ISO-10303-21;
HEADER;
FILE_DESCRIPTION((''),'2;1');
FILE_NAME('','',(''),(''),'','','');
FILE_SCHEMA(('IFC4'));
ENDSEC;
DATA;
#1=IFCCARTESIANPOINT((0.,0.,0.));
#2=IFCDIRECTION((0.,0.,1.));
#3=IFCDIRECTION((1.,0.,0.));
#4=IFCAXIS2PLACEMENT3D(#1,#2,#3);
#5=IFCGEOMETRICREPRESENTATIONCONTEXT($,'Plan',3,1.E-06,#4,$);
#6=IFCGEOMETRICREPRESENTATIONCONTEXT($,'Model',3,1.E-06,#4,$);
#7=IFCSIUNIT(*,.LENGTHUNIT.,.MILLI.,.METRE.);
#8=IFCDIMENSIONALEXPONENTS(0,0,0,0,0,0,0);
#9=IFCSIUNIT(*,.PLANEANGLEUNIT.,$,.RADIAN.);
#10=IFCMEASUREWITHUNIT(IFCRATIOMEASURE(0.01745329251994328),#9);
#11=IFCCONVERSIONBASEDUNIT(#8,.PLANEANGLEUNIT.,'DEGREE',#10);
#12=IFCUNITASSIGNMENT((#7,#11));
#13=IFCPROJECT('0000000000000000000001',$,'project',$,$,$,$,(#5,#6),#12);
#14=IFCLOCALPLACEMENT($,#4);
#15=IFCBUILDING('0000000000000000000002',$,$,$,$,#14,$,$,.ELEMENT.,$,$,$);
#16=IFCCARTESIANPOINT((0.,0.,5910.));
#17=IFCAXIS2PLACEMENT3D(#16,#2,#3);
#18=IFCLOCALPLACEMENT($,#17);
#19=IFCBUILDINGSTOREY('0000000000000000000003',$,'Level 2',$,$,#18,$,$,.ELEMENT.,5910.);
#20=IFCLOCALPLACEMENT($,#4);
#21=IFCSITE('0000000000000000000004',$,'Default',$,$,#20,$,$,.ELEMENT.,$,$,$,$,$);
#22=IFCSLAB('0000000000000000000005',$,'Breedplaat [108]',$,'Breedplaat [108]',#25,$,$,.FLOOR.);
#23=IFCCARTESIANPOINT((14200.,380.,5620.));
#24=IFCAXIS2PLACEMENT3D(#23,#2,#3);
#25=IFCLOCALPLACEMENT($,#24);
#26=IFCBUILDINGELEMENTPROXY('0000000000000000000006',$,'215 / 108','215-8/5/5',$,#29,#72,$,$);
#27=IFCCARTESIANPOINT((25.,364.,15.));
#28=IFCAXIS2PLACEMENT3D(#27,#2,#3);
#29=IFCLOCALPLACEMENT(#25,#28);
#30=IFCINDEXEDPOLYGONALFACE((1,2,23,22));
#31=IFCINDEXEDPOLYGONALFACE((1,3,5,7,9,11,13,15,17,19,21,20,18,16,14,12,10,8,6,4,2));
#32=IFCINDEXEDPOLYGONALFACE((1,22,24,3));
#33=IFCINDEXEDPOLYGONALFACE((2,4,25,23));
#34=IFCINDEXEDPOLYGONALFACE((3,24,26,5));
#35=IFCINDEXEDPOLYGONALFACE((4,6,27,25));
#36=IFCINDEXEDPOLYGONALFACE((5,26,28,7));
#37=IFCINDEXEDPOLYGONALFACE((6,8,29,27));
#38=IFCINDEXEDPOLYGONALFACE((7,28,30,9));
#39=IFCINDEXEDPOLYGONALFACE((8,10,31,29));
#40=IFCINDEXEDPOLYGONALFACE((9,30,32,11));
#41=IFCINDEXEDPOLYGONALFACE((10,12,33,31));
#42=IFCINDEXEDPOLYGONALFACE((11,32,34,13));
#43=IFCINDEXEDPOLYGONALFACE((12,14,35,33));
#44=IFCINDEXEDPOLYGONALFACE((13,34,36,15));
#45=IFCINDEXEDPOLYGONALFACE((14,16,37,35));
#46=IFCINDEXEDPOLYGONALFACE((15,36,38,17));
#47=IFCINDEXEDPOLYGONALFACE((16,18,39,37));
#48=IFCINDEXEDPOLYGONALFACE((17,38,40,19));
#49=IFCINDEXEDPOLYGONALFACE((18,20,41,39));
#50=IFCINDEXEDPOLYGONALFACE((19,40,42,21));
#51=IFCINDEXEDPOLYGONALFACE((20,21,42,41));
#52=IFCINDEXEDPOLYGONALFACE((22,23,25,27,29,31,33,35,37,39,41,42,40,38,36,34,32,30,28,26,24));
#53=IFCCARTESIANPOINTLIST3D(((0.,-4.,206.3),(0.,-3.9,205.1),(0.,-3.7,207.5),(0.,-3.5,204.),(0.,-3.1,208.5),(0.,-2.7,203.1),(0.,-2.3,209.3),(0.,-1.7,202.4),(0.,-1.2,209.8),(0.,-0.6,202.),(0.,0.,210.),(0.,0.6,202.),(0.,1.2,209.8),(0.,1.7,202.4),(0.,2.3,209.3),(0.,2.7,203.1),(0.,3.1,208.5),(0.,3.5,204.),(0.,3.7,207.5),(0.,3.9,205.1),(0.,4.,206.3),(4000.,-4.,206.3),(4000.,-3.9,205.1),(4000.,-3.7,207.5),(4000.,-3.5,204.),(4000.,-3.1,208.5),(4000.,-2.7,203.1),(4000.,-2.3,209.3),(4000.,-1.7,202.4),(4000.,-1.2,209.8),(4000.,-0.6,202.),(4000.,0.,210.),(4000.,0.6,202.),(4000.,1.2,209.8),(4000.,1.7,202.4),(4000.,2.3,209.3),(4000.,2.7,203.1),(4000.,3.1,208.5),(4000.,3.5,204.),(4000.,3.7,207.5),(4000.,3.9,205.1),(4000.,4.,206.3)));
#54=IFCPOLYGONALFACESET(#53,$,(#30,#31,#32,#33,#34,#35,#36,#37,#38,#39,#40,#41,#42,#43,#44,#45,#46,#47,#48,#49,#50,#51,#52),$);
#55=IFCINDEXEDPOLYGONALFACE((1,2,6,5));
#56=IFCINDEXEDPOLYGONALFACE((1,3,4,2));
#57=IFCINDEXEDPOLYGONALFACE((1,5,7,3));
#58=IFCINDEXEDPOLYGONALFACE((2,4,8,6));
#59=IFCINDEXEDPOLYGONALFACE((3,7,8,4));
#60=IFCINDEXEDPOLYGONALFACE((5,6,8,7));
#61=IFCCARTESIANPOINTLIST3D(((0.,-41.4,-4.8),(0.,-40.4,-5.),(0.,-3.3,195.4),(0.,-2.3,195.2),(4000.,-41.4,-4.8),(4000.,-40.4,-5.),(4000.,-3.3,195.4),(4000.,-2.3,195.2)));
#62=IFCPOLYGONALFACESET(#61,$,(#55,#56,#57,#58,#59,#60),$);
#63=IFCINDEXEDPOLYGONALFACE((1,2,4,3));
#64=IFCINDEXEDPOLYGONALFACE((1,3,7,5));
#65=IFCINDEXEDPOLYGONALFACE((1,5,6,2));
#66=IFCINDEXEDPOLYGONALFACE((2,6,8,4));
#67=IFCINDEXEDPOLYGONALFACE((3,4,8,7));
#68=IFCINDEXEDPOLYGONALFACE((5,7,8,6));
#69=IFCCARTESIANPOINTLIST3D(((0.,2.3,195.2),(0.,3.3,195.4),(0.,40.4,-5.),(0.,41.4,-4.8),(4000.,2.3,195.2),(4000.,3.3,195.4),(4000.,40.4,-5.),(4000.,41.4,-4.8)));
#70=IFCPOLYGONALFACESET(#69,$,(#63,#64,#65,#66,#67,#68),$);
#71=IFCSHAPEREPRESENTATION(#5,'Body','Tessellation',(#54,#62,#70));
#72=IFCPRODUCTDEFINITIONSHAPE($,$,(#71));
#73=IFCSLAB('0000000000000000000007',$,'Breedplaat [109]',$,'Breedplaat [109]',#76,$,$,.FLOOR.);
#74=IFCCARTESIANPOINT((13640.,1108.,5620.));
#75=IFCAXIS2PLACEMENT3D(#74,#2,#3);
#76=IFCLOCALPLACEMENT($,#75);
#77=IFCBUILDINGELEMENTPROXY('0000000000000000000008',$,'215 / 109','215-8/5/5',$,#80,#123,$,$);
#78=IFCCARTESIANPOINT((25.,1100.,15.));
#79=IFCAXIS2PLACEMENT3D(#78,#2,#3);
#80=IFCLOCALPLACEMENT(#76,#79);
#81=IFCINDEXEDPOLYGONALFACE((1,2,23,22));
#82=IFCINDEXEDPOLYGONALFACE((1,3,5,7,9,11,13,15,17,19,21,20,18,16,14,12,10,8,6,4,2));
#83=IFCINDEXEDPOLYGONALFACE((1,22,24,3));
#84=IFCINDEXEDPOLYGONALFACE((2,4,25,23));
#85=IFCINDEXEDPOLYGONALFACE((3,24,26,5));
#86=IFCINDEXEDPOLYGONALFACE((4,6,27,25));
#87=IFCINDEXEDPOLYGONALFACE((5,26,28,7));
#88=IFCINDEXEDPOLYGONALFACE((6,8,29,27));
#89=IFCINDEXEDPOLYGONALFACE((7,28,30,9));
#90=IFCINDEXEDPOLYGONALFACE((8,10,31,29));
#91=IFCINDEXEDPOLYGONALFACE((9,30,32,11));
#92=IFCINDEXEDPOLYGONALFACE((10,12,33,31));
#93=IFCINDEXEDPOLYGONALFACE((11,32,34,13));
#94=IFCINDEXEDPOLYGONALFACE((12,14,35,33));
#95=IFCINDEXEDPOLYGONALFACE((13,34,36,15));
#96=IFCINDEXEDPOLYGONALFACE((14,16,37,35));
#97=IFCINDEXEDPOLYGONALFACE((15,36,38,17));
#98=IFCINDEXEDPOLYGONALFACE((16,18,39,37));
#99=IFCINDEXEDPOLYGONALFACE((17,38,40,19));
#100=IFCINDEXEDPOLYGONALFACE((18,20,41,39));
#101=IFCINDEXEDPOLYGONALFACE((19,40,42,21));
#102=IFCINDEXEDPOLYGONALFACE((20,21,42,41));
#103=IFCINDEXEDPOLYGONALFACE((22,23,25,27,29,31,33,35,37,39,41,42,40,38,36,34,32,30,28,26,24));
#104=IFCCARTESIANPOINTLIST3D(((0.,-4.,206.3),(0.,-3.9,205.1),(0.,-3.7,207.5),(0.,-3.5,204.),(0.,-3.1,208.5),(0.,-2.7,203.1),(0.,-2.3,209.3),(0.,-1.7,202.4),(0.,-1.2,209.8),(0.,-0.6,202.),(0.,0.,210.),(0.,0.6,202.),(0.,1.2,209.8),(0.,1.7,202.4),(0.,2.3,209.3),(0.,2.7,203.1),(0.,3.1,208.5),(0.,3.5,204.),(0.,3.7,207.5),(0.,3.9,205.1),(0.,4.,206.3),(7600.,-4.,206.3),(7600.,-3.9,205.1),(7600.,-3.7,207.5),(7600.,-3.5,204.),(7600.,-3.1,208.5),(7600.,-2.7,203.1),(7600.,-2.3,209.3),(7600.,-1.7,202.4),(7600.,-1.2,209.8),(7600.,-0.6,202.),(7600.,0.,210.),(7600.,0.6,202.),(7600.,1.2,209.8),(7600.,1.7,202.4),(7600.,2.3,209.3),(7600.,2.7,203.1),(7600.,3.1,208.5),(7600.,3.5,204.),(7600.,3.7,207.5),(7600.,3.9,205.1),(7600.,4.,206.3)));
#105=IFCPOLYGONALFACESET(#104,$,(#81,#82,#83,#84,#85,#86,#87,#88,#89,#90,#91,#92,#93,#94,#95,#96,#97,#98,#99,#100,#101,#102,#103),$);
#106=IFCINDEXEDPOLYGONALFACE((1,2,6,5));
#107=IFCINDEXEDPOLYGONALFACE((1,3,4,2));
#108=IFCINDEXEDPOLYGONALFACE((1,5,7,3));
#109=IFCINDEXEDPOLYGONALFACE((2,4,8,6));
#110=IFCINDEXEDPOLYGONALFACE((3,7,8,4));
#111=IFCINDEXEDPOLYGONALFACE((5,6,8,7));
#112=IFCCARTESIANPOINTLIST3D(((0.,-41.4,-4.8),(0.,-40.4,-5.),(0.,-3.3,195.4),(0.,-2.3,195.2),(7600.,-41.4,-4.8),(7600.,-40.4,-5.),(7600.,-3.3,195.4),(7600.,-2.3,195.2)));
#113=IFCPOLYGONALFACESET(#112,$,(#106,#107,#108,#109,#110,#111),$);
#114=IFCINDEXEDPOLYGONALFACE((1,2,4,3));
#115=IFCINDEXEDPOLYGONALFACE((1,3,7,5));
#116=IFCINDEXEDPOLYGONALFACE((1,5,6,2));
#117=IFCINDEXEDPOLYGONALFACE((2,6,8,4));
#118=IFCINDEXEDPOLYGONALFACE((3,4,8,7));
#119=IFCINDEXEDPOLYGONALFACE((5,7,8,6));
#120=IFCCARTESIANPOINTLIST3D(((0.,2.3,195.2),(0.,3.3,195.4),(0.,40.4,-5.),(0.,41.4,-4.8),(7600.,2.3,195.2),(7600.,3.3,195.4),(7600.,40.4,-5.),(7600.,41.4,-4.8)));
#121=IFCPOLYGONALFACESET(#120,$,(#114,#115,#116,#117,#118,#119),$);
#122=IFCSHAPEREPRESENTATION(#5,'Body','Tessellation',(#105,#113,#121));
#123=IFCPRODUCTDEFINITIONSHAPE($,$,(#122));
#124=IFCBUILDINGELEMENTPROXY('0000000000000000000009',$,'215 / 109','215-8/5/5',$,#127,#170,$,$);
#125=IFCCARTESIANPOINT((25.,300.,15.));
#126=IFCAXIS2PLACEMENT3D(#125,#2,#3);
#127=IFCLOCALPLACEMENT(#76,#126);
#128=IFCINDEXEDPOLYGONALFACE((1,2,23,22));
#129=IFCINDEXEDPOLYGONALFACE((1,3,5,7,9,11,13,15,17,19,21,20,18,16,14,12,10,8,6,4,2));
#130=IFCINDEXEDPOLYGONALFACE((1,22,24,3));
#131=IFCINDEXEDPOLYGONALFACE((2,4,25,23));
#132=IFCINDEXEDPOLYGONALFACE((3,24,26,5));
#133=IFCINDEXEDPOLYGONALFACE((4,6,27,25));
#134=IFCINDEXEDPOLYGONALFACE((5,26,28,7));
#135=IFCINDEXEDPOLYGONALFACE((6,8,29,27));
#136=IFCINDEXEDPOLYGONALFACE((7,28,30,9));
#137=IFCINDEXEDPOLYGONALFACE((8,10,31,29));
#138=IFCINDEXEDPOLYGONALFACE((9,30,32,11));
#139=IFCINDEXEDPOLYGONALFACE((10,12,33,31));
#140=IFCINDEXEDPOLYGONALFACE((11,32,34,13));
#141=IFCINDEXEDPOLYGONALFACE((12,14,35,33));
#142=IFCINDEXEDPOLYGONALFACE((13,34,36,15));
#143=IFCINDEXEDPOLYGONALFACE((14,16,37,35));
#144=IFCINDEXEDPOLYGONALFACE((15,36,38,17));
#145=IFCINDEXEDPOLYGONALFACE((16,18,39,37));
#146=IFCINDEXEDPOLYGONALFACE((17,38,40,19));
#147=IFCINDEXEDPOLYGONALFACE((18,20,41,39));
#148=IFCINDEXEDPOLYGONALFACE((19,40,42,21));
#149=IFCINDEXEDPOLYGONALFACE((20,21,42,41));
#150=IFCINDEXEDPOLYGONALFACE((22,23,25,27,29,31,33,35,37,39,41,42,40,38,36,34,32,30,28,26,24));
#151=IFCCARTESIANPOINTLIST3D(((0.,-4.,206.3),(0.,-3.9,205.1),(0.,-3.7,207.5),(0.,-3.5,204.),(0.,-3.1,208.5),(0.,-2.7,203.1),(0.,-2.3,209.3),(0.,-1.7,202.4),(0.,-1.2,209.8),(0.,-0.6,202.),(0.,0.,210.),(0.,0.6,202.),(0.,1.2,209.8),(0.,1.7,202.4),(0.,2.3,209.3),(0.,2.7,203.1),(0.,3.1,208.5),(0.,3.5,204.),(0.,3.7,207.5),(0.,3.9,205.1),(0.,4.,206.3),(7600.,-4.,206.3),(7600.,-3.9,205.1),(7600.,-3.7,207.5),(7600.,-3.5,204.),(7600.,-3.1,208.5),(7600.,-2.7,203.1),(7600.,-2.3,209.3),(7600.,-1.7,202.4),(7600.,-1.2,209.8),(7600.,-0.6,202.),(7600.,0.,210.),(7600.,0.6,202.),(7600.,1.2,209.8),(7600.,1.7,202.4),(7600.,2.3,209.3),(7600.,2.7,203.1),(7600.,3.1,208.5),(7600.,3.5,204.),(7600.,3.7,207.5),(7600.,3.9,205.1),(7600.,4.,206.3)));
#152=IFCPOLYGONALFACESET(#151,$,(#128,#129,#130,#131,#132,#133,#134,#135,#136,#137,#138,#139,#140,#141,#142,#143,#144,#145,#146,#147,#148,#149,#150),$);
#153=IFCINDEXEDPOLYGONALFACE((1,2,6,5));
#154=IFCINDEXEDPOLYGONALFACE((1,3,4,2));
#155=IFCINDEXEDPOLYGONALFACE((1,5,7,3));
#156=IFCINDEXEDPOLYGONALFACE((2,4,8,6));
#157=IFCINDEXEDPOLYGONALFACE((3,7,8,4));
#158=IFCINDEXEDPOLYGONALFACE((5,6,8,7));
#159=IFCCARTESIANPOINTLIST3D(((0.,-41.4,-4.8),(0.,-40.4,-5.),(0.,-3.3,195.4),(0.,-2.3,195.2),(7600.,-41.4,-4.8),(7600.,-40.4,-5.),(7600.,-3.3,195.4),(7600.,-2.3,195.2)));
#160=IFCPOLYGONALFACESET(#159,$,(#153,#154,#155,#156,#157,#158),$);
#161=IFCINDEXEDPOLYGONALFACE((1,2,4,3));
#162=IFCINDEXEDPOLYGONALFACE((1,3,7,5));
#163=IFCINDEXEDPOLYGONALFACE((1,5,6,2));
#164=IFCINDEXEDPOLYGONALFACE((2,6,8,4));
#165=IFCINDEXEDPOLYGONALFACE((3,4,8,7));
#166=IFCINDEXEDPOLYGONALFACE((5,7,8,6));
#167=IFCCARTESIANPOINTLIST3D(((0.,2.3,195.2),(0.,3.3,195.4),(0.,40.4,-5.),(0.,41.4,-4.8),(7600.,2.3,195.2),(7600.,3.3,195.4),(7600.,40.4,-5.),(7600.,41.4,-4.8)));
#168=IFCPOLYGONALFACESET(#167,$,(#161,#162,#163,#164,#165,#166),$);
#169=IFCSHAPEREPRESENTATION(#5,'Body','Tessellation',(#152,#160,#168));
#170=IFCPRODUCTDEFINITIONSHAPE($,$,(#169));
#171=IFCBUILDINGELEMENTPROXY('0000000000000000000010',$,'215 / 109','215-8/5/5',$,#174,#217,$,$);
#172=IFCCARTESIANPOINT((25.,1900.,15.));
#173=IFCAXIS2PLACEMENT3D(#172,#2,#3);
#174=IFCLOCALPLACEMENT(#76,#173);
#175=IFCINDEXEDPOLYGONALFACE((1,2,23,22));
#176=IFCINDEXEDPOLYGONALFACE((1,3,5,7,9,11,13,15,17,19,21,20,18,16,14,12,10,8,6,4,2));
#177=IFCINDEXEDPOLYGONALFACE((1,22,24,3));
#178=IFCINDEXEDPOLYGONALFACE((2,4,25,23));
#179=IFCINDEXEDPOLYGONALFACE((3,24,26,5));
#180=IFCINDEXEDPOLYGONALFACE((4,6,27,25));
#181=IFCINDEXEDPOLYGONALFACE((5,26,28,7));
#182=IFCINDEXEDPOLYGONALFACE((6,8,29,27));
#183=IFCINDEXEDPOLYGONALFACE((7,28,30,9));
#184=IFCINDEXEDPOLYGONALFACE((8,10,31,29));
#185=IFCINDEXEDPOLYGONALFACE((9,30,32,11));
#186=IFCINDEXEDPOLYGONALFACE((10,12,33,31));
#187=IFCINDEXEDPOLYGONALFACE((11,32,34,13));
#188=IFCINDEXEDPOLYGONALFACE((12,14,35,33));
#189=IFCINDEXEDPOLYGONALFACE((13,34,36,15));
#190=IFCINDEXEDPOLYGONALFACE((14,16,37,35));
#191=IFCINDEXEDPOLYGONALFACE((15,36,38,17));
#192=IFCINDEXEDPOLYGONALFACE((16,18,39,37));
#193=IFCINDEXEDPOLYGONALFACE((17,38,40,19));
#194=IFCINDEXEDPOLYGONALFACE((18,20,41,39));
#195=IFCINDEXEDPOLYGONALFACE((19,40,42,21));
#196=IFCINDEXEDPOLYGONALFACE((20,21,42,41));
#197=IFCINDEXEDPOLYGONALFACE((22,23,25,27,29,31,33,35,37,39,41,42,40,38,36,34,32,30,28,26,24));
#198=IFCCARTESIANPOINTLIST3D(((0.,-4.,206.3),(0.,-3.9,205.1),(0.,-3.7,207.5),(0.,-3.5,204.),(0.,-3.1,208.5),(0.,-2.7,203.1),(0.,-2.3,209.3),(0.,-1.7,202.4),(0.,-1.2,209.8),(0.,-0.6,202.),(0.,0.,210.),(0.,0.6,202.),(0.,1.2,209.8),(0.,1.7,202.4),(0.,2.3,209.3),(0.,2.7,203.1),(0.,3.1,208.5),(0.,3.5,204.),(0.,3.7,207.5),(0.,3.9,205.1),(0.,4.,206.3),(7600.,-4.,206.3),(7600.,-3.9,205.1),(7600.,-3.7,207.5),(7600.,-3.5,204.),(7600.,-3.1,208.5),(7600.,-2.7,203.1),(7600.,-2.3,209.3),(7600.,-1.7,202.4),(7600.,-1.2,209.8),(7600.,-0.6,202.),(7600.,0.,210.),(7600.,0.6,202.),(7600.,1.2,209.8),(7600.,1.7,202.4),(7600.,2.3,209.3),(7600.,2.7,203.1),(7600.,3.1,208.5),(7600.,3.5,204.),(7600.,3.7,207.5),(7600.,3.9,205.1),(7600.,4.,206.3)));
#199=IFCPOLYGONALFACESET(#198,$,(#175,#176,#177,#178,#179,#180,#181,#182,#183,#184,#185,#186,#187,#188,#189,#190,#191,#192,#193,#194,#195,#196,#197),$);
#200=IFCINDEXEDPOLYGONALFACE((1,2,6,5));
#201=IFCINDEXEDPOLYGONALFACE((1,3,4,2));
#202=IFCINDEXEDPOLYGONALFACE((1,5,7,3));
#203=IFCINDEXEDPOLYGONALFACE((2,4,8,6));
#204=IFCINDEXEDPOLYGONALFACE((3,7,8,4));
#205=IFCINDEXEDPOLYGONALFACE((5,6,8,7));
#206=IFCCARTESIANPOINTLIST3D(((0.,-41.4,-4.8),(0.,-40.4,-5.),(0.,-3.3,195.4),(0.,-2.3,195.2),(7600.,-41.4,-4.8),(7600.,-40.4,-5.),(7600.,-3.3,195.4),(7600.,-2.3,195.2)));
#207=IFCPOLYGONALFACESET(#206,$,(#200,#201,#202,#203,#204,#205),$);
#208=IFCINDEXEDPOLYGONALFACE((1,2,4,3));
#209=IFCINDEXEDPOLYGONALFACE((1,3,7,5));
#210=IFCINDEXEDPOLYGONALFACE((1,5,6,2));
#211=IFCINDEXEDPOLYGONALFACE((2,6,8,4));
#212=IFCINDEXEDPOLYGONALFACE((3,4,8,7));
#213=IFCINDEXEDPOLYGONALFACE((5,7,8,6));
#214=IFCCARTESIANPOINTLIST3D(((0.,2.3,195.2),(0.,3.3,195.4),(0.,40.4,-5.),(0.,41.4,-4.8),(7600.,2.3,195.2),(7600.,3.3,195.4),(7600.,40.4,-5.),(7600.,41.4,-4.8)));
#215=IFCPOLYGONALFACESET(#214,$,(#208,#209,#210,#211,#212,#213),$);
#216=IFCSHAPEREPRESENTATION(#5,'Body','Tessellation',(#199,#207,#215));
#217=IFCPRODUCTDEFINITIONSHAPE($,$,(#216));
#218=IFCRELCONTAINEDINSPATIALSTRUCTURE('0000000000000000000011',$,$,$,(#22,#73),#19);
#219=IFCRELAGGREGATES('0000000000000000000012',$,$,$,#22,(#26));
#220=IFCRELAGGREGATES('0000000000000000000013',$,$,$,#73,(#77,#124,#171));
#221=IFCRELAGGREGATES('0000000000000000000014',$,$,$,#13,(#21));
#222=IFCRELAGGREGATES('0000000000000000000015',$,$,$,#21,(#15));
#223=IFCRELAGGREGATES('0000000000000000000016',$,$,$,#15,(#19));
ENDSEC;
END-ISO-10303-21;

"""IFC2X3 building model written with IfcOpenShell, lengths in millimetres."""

from ifc_helpers import new_model, entity, si_unit, converted_unit, frame, origin_with_axes, origin_2d_with_axis, place, context, project, spatial, rectangle, circle, extrude, element, aggregate, save


model = new_model("IFC2X3")

# Units and contexts
plan_context = context("Plan", 3, precision=1e-06, world=origin_with_axes())
model_context = context("Model", 3, precision=1e-06, world=origin_with_axes())
ifc_project = project(units=[si_unit("LENGTHUNIT", "METRE", prefix="MILLI"), converted_unit("PLANEANGLEUNIT", "DEGREE", entity("IfcRatioMeasure", 0.01745329251994328), si_unit("PLANEANGLEUNIT", "RADIAN"), dimensions=[0, 0, 0, 0, 0, 0, 0])], contexts=[plan_context, model_context])

# Site, building, storey
site_placement = place(None, origin_with_axes())
site = spatial("IfcSite", under=ifc_project, at=site_placement, Name="Default", CompositionType="ELEMENT")
building_placement = place(None, origin_with_axes())
building = spatial("IfcBuilding", under=site, at=building_placement, CompositionType="ELEMENT")
storey_placement = place(None, frame((0.0, 0.0, 5910.0), z_axis=(0.0, 0.0, 1.0), x_axis=(1.0, 0.0, 0.0)))
storey = spatial("IfcBuildingStorey", under=building, at=storey_placement, Name="Level 2", CompositionType="ELEMENT", Elevation=5910.0)

# Slab, building element proxy
slab_1_placement = place(None, frame((14200.0, 380.0, 5620.0), z_axis=(0.0, 0.0, 1.0), x_axis=(1.0, 0.0, 0.0)))
slab_1 = element("IfcSlab", 1, at=slab_1_placement, inside=storey, Name="Breedplaat [108]", ObjectType="Breedplaat [108]", PredefinedType="FLOOR")
proxy_1_placement = place(slab_1_placement, frame((25.0, 364.0, 15.0), z_axis=(0.0, 0.0, 1.0), x_axis=(1.0, 0.0, 0.0)))
proxy_1 = element("IfcBuildingElementProxy", 2, at=proxy_1_placement, Name="215 / 108", Description="215-8/5/5", context=plan_context, shape_type="SweptSolid", body=[
    extrude(circle(Radius=4.0, at=origin_2d_with_axis()), frame((0.0, 0.0, 206.0), z_axis=(1.0, 0.0, 0.0), x_axis=(0.0, 0.0, 1.0)), (0.0, 0.0, 1.0), 4000.0),
    extrude(rectangle(XDim=203.8, YDim=1.0, at=origin_2d_with_axis()), frame((0.0, -21.9, 95.2), z_axis=(1.0, 0.0, 0.0), x_axis=(0.0, 0.187112, 0.982339)), (0.0, 0.0, 1.0), 4000.0),
    extrude(rectangle(XDim=203.8, YDim=1.0, at=origin_2d_with_axis()), frame((0.0, 21.9, 95.2), z_axis=(1.0, 0.0, 0.0), x_axis=(0.0, -0.187112, 0.982339)), (0.0, 0.0, 1.0), 4000.0),
])
aggregate(slab_1, [proxy_1])

# Slab, building element proxies
slab_2_placement = place(None, frame((13640.0, 1108.0, 5620.0), z_axis=(0.0, 0.0, 1.0), x_axis=(1.0, 0.0, 0.0)))
slab_2 = element("IfcSlab", 3, at=slab_2_placement, inside=storey, Name="Breedplaat [109]", ObjectType="Breedplaat [109]", PredefinedType="FLOOR")
proxy_2_placement = place(slab_2_placement, frame((25.0, 1100.0, 15.0), z_axis=(0.0, 0.0, 1.0), x_axis=(1.0, 0.0, 0.0)))
proxy_2 = element("IfcBuildingElementProxy", 4, at=proxy_2_placement, Name="215 / 109", Description="215-8/5/5", context=plan_context, shape_type="SweptSolid", body=[
    extrude(circle(Radius=4.0, at=origin_2d_with_axis()), frame((0.0, 0.0, 206.0), z_axis=(1.0, 0.0, 0.0), x_axis=(0.0, 0.0, 1.0)), (0.0, 0.0, 1.0), 7600.0),
    extrude(rectangle(XDim=203.8, YDim=1.0, at=origin_2d_with_axis()), frame((0.0, -21.9, 95.2), z_axis=(1.0, 0.0, 0.0), x_axis=(0.0, 0.187112, 0.982339)), (0.0, 0.0, 1.0), 7600.0),
    extrude(rectangle(XDim=203.8, YDim=1.0, at=origin_2d_with_axis()), frame((0.0, 21.9, 95.2), z_axis=(1.0, 0.0, 0.0), x_axis=(0.0, -0.187112, 0.982339)), (0.0, 0.0, 1.0), 7600.0),
])
proxy_3_placement = place(slab_2_placement, frame((25.0, 300.0, 15.0), z_axis=(0.0, 0.0, 1.0), x_axis=(1.0, 0.0, 0.0)))
proxy_3 = element("IfcBuildingElementProxy", 5, at=proxy_3_placement, Name="215 / 109", Description="215-8/5/5", context=plan_context, shape_type="SweptSolid", body=[
    extrude(circle(Radius=4.0, at=origin_2d_with_axis()), frame((0.0, 0.0, 206.0), z_axis=(1.0, 0.0, 0.0), x_axis=(0.0, 0.0, 1.0)), (0.0, 0.0, 1.0), 7600.0),
    extrude(rectangle(XDim=203.8, YDim=1.0, at=origin_2d_with_axis()), frame((0.0, -21.9, 95.2), z_axis=(1.0, 0.0, 0.0), x_axis=(0.0, 0.187112, 0.982339)), (0.0, 0.0, 1.0), 7600.0),
    extrude(rectangle(XDim=203.8, YDim=1.0, at=origin_2d_with_axis()), frame((0.0, 21.9, 95.2), z_axis=(1.0, 0.0, 0.0), x_axis=(0.0, -0.187112, 0.982339)), (0.0, 0.0, 1.0), 7600.0),
])
proxy_4_placement = place(slab_2_placement, frame((25.0, 1900.0, 15.0), z_axis=(0.0, 0.0, 1.0), x_axis=(1.0, 0.0, 0.0)))
proxy_4 = element("IfcBuildingElementProxy", 6, at=proxy_4_placement, Name="215 / 109", Description="215-8/5/5", context=plan_context, shape_type="SweptSolid", body=[
    extrude(circle(Radius=4.0, at=origin_2d_with_axis()), frame((0.0, 0.0, 206.0), z_axis=(1.0, 0.0, 0.0), x_axis=(0.0, 0.0, 1.0)), (0.0, 0.0, 1.0), 7600.0),
    extrude(rectangle(XDim=203.8, YDim=1.0, at=origin_2d_with_axis()), frame((0.0, -21.9, 95.2), z_axis=(1.0, 0.0, 0.0), x_axis=(0.0, 0.187112, 0.982339)), (0.0, 0.0, 1.0), 7600.0),
    extrude(rectangle(XDim=203.8, YDim=1.0, at=origin_2d_with_axis()), frame((0.0, 21.9, 95.2), z_axis=(1.0, 0.0, 0.0), x_axis=(0.0, -0.187112, 0.982339)), (0.0, 0.0, 1.0), 7600.0),
])
aggregate(slab_2, [proxy_2, proxy_3, proxy_4])

save(model, "model.ifc")
